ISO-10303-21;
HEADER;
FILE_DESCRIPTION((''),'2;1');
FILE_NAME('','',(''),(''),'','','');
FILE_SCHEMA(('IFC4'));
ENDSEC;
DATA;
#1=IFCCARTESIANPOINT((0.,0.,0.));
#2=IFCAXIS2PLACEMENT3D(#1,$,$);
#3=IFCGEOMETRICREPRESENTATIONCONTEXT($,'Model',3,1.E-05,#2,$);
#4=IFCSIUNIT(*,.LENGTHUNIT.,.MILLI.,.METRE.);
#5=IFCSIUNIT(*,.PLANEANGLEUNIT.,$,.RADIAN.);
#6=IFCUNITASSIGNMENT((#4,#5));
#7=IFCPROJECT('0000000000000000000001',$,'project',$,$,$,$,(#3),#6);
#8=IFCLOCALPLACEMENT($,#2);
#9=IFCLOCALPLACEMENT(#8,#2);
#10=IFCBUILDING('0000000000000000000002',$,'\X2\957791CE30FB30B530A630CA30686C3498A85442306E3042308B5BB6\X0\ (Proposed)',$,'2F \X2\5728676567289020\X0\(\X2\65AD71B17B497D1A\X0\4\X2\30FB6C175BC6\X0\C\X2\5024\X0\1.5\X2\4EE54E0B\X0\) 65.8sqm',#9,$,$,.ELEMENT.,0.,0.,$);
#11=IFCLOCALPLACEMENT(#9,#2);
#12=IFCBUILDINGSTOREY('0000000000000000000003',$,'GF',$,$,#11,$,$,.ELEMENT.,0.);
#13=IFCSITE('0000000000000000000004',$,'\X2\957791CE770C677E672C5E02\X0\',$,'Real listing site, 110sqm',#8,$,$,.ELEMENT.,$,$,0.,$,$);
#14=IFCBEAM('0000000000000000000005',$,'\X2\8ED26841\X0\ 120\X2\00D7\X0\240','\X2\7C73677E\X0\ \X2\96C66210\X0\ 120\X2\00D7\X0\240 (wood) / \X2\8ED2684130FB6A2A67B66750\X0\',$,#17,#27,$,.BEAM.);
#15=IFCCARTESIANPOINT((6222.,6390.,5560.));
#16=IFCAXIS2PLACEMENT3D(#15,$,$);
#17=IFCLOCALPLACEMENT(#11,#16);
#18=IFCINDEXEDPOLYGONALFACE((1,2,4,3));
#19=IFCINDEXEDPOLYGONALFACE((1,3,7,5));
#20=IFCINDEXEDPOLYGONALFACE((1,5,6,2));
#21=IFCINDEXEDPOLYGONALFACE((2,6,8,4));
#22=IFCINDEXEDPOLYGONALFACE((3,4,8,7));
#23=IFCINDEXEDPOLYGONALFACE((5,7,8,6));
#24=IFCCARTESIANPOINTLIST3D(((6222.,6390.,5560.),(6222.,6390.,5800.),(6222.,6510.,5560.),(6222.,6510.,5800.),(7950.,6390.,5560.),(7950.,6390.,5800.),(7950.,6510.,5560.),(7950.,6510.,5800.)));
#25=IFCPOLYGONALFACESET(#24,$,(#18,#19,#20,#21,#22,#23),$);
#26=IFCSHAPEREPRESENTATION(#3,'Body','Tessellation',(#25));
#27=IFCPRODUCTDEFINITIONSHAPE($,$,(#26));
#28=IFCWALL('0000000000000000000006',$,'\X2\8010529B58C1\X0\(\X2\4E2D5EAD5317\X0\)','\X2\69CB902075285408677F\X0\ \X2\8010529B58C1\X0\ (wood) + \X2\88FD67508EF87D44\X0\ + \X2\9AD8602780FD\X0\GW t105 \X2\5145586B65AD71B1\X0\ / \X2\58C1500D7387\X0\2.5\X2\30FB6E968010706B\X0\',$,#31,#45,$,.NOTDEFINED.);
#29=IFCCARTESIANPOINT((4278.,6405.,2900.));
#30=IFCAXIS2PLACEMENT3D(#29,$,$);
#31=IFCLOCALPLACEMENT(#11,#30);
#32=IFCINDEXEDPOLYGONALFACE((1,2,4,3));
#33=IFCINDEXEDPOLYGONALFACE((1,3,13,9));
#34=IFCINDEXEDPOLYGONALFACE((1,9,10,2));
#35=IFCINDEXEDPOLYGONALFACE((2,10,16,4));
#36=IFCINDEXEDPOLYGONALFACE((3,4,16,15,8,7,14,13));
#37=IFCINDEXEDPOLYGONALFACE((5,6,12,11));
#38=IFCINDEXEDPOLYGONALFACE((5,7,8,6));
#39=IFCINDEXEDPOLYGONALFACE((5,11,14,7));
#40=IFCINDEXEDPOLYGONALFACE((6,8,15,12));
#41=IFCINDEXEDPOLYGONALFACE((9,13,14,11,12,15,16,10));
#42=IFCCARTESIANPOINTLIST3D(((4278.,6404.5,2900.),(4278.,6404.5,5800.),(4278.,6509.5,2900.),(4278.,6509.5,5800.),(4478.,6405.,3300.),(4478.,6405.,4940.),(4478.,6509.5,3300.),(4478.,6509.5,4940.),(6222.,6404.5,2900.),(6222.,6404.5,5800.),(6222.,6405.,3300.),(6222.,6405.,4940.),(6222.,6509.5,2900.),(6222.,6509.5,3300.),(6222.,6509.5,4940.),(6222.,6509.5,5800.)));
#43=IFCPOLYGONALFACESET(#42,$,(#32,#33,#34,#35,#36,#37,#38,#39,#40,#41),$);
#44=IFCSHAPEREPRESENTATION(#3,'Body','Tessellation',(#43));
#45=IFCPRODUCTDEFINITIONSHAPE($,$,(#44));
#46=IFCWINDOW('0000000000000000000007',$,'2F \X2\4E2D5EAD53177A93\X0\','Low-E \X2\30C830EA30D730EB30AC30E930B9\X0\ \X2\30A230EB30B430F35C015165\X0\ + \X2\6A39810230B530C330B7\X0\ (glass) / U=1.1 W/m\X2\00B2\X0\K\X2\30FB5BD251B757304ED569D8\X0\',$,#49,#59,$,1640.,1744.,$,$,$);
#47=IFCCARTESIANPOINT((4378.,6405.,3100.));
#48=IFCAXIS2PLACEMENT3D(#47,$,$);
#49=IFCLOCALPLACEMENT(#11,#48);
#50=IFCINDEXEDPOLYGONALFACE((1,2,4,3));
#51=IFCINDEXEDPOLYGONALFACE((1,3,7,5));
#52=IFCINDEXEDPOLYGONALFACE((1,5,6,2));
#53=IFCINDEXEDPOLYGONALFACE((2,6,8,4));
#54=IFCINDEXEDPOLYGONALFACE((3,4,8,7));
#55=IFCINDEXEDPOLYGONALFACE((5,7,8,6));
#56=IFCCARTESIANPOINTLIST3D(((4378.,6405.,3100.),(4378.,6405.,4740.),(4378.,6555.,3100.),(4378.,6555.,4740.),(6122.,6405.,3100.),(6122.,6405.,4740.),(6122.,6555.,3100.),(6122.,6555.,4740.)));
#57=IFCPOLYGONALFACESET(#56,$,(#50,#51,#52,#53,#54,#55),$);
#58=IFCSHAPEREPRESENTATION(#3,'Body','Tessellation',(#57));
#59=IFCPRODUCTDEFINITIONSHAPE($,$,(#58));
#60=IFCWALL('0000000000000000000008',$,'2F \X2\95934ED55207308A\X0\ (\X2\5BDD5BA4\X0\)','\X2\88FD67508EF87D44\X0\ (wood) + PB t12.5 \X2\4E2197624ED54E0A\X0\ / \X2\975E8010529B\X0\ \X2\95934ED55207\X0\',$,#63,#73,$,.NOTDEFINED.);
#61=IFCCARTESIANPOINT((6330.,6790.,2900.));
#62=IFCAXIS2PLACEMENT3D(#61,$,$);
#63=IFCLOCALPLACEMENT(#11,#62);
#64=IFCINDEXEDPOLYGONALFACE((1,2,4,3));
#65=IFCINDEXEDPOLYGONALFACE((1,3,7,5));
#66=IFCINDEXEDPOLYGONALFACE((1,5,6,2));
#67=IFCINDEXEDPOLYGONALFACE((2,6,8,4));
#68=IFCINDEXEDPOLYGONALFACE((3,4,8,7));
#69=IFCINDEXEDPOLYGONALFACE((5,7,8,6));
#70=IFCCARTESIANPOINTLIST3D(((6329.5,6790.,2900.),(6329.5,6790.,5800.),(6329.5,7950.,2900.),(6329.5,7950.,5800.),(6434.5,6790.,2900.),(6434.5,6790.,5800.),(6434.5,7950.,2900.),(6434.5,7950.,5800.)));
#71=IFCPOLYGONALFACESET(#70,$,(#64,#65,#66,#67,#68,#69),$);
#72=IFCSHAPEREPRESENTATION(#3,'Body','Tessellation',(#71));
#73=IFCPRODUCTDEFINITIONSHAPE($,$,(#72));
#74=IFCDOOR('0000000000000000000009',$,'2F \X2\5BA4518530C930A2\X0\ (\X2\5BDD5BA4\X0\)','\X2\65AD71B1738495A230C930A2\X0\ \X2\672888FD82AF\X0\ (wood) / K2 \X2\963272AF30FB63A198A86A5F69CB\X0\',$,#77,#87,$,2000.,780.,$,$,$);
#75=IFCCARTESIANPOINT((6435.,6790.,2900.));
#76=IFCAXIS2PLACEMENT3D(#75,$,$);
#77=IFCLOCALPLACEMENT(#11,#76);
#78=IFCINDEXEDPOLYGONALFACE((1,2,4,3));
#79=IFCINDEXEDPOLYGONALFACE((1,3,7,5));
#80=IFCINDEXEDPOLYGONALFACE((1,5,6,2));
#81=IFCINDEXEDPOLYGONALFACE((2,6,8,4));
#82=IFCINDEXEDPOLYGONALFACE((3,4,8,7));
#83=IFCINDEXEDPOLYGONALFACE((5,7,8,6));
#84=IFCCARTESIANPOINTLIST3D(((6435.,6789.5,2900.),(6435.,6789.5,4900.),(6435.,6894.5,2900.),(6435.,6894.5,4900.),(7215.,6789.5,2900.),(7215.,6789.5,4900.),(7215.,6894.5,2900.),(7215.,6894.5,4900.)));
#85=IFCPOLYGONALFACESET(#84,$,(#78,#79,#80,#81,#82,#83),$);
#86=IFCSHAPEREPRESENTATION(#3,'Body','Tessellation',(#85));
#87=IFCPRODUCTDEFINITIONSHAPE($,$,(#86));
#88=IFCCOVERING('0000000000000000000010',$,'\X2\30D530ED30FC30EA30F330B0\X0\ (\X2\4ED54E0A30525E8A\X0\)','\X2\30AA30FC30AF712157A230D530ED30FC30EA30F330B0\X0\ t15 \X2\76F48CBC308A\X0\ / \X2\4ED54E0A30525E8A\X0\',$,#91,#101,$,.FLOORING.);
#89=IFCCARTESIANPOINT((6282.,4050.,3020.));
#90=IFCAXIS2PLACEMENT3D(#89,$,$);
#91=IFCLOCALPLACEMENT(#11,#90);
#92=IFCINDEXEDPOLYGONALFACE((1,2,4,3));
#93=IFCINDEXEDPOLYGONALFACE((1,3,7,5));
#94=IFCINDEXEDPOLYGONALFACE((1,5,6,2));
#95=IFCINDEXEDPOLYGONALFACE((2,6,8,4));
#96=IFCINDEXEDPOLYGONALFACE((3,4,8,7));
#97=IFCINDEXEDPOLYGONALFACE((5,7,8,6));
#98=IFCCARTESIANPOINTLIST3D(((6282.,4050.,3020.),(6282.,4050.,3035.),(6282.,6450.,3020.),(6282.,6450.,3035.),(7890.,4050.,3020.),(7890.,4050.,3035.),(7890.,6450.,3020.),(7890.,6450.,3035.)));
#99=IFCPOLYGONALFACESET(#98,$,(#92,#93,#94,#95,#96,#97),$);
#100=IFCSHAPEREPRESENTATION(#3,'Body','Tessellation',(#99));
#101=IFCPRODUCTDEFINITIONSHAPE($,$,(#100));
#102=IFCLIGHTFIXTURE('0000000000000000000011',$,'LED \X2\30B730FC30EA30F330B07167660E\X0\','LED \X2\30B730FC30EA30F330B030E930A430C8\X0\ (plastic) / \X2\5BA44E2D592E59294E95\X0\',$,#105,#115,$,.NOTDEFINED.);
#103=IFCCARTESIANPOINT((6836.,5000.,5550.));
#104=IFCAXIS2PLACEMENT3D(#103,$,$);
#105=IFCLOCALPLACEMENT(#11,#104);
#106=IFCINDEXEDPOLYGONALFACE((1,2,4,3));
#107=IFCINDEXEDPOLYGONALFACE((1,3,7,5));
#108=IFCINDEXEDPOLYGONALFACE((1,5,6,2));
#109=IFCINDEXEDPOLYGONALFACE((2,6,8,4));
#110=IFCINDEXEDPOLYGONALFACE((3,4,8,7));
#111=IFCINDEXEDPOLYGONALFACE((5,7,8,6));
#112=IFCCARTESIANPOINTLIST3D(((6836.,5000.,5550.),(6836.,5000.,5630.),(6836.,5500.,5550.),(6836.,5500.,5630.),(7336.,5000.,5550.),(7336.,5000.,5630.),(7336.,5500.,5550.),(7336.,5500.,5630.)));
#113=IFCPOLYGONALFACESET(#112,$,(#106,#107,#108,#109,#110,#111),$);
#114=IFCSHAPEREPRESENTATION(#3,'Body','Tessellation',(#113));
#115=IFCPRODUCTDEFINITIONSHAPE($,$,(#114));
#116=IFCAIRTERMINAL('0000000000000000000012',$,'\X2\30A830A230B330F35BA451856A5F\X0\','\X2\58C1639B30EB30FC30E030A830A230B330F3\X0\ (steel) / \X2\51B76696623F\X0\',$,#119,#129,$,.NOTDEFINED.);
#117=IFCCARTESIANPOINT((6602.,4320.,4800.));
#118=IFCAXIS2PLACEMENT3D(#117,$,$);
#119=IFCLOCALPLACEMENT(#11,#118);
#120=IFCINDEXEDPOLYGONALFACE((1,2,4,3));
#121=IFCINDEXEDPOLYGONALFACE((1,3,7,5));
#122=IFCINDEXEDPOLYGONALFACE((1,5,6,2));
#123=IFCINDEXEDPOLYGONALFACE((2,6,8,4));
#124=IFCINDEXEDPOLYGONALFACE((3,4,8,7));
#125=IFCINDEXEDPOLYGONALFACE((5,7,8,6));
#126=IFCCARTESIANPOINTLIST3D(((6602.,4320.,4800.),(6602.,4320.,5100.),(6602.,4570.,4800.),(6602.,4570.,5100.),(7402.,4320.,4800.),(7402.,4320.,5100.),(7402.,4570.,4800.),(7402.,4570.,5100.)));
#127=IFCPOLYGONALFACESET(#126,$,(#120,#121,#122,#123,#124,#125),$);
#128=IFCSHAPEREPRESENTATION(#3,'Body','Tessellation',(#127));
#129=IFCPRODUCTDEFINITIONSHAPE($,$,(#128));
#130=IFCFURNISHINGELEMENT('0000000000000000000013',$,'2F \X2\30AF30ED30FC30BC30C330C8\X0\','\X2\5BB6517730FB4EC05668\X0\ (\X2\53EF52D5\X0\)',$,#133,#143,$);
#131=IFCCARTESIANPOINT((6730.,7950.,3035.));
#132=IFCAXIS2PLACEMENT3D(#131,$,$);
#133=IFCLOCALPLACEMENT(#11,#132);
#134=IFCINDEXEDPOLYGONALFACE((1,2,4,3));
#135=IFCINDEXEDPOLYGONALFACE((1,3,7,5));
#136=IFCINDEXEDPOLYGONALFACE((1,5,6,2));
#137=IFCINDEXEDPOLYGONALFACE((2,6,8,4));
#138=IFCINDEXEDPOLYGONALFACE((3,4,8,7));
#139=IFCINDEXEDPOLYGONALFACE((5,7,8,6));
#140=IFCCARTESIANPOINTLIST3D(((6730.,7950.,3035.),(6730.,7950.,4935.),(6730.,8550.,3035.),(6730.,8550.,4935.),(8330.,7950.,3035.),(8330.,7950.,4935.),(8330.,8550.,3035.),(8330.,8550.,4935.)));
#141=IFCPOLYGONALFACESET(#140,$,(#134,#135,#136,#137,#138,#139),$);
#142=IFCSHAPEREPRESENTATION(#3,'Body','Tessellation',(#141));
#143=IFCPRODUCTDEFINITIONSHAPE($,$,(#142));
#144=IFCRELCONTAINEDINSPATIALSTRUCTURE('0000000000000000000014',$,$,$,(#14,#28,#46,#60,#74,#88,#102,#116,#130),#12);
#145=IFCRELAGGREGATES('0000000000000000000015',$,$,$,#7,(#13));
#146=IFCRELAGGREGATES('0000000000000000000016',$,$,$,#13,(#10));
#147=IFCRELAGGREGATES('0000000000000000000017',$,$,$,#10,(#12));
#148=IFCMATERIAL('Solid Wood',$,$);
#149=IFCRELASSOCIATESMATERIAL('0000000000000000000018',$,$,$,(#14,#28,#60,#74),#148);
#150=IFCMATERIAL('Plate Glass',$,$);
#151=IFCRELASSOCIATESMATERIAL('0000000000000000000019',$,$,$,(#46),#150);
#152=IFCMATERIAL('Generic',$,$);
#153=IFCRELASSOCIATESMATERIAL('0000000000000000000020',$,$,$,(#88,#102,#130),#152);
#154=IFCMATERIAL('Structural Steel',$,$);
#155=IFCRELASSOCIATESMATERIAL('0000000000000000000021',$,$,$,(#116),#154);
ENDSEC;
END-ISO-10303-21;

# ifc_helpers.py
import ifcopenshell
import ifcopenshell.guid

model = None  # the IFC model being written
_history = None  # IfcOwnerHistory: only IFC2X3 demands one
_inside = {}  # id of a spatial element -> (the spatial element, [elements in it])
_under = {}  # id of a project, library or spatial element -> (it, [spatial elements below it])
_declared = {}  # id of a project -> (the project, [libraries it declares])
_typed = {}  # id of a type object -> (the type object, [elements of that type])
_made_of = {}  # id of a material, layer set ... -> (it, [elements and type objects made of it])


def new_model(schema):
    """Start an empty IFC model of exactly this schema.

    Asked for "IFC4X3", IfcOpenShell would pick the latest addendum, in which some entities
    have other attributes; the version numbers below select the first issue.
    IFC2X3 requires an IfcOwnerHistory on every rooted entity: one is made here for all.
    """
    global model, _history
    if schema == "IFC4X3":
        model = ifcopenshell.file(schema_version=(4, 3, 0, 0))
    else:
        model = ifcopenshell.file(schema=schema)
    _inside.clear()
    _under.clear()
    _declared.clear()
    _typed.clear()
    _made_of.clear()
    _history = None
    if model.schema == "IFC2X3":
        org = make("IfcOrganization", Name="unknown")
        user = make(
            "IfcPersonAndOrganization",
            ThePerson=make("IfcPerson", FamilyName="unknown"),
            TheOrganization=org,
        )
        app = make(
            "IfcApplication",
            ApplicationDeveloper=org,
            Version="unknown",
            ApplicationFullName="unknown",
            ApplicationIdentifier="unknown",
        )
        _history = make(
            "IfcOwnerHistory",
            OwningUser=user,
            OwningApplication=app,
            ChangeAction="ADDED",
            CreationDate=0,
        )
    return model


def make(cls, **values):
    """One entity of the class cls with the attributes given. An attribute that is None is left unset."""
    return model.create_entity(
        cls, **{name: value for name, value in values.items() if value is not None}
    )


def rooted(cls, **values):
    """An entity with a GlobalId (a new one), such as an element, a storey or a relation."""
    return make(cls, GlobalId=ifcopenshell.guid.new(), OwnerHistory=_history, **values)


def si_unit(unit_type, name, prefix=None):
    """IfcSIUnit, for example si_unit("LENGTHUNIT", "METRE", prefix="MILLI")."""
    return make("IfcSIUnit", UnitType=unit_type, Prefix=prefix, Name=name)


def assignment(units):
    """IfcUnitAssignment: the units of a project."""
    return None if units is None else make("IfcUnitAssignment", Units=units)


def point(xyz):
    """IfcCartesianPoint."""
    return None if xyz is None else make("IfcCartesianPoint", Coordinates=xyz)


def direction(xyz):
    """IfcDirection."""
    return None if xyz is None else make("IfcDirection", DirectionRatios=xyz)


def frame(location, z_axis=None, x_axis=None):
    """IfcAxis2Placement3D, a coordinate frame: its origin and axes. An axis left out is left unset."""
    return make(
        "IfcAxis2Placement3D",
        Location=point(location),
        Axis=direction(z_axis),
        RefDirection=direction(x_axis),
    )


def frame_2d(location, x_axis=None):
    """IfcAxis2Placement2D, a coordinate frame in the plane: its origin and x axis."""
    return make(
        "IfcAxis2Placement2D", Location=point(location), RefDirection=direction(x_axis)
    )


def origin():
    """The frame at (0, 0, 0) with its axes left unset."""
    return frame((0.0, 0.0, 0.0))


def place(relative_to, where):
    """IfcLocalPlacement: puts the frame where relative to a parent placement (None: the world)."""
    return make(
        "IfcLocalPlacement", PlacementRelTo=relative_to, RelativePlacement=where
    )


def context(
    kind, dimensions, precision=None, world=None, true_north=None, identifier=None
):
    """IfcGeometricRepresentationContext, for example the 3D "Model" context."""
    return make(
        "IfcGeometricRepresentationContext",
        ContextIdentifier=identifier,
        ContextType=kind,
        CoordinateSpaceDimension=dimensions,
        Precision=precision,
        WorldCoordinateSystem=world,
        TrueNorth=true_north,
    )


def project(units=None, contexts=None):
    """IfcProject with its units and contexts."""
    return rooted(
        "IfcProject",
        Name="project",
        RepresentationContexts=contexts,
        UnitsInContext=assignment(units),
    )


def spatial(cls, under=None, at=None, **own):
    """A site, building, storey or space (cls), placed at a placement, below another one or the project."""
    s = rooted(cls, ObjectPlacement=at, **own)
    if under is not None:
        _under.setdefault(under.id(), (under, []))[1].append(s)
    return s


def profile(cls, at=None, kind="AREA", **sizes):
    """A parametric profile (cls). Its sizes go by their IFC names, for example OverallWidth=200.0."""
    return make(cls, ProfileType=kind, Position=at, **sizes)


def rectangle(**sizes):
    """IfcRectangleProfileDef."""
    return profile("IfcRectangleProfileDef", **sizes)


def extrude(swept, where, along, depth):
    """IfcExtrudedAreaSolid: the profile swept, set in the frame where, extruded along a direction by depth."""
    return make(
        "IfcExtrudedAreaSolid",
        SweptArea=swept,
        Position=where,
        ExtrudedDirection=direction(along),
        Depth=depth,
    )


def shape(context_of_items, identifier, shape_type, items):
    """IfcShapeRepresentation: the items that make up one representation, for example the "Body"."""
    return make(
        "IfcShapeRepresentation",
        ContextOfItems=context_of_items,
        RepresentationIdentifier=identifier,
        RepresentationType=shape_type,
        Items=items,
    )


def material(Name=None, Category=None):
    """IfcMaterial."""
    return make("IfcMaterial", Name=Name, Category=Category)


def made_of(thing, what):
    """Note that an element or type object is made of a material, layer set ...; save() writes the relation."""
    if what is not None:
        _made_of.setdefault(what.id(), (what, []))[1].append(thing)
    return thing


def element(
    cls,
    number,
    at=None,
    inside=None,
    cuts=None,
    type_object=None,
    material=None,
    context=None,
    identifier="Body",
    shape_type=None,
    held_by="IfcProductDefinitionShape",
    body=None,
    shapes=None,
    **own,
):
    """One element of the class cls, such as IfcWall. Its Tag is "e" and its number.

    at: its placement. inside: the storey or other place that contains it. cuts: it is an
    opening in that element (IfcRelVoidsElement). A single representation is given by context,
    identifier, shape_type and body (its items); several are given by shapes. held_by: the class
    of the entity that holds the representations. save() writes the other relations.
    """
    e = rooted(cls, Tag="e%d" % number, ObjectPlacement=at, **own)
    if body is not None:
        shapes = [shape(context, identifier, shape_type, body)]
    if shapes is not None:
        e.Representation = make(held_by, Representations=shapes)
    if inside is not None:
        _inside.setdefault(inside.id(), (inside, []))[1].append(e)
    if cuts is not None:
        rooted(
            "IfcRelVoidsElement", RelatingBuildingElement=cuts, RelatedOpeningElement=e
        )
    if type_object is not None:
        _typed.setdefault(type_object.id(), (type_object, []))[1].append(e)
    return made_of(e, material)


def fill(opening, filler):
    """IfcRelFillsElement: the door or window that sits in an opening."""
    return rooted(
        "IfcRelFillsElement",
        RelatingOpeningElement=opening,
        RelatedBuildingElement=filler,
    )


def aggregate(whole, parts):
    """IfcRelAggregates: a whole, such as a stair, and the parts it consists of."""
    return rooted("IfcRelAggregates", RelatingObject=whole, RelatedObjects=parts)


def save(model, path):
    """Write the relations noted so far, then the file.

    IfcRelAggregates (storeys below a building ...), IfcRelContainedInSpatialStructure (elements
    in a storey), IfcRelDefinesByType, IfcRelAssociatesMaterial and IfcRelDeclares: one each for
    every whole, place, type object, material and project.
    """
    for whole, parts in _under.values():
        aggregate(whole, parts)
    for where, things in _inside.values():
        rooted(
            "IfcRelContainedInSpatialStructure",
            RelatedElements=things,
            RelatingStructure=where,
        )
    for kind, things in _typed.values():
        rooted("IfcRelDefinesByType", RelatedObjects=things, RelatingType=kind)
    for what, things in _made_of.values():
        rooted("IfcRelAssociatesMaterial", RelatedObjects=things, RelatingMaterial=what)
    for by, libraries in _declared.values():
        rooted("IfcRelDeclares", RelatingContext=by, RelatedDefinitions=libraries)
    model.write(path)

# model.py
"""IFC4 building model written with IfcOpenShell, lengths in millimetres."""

from ifc_helpers import new_model, si_unit, frame, frame_2d, origin, place, context, project, spatial, rectangle, extrude, material, element, fill, save


model = new_model("IFC4")

# Units and contexts
model_context = context("Model", 3, precision=1e-05, world=origin())
ifc_project = project(units=[si_unit("LENGTHUNIT", "METRE", prefix="MILLI"), si_unit("PLANEANGLEUNIT", "RADIAN")], contexts=[model_context])

# Site, building, storey
site_placement = place(None, origin())
site = spatial("IfcSite", under=ifc_project, at=site_placement, Name="長野県松本市", ObjectType="Real listing site, 110sqm", CompositionType="ELEMENT", RefElevation=0.0)
building_placement = place(site_placement, origin())
building = spatial("IfcBuilding", under=site, at=building_placement, Name="長野・サウナと水風呂のある家 (Proposed)", ObjectType="2F 在来木造(断熱等級4・気密C値1.5以下) 65.8sqm", CompositionType="ELEMENT", ElevationOfRefHeight=0.0, ElevationOfTerrain=0.0)
storey_placement = place(building_placement, origin())
storey = spatial("IfcBuildingStorey", under=building, at=storey_placement, Name="GF", CompositionType="ELEMENT", Elevation=0.0)

# Shared definitions
ifc_material_1 = material(Name="Solid Wood")

# Beam
beam_1_placement = place(storey_placement, frame((6222.0, 6390.0, 5560.0)))
element("IfcBeam", 1, at=beam_1_placement, inside=storey, material=ifc_material_1, Name="軒桁 120×240", Description="米松 集成 120×240 (wood) / 軒桁・横架材", PredefinedType="BEAM", context=model_context, shape_type="SweptSolid", body=[
    extrude(rectangle(XDim=1728.0, YDim=120.0, at=frame_2d((864.0, 60.0))), frame((6222.0, 6390.0, 5560.0)), (0.0, 0.0, 1.0), 240.0),
])

# Wall, opening, window
wall_1_placement = place(storey_placement, frame((4278.0, 6405.0, 2900.0)))
wall_1 = element("IfcWall", 2, at=wall_1_placement, inside=storey, material=ifc_material_1, Name="耐力壁(中庭北)", Description="構造用合板 耐力壁 (wood) + 製材軸組 + 高性能GW t105 充填断熱 / 壁倍率2.5・準耐火", PredefinedType="NOTDEFINED", context=model_context, shape_type="SweptSolid", body=[
    extrude(rectangle(XDim=1944.0, YDim=105.0, at=frame_2d((972.0, 52.0))), frame((4278.0, 6405.0, 2900.0)), (0.0, 0.0, 1.0), 2900.0),
])
opening_placement = place(storey_placement, frame((4378.0, 6405.0, 3100.0)))
opening = element("IfcOpeningElement", 3, at=opening_placement, cuts=wall_1, PredefinedType="NOTDEFINED", context=model_context, shape_type="SweptSolid", body=[
    extrude(rectangle(XDim=1744.0, YDim=150.0, at=frame_2d((872.0, 75.0))), frame((4378.0, 6405.0, 3100.0)), (0.0, 0.0, 1.0), 1640.0),
])
ifc_material_2 = material(Name="Plate Glass")
window_placement = place(storey_placement, frame((4378.0, 6405.0, 3100.0)))
window = element("IfcWindow", 4, at=window_placement, inside=storey, material=ifc_material_2, Name="2F 中庭北窓", Description="Low-E トリプルガラス アルゴン封入 + 樹脂サッシ (glass) / U=1.1 W/m²K・寒冷地仕様", OverallHeight=1640.0, OverallWidth=1744.0, context=model_context, shape_type="SweptSolid", body=[
    extrude(rectangle(XDim=1744.0, YDim=150.0, at=frame_2d((872.0, 75.0))), frame((4378.0, 6405.0, 3100.0)), (0.0, 0.0, 1.0), 1640.0),
])
fill(opening, window)

# Wall
wall_2_placement = place(storey_placement, frame((6330.0, 6790.0, 2900.0)))
element("IfcWall", 5, at=wall_2_placement, inside=storey, material=ifc_material_1, Name="2F 間仕切り (寝室)", Description="製材軸組 (wood) + PB t12.5 両面仕上 / 非耐力 間仕切", PredefinedType="NOTDEFINED", context=model_context, shape_type="SweptSolid", body=[
    extrude(rectangle(XDim=105.0, YDim=1160.0, at=frame_2d((52.0, 580.0))), frame((6330.0, 6790.0, 2900.0)), (0.0, 0.0, 1.0), 2900.0),
])

# Door
door_placement = place(storey_placement, frame((6435.0, 6790.0, 2900.0)))
element("IfcDoor", 6, at=door_placement, inside=storey, material=ifc_material_1, Name="2F 室内ドア (寝室)", Description="断熱玄関ドア 木製芯 (wood) / K2 防犯・採風機構", OverallHeight=2000.0, OverallWidth=780.0, context=model_context, shape_type="SweptSolid", body=[
    extrude(rectangle(XDim=780.0, YDim=105.0, at=frame_2d((390.0, 52.0))), frame((6435.0, 6790.0, 2900.0)), (0.0, 0.0, 1.0), 2000.0),
])

# Covering
ifc_material_3 = material(Name="Generic")
covering_placement = place(storey_placement, frame((6282.0, 4050.0, 3020.0)))
element("IfcCovering", 7, at=covering_placement, inside=storey, material=ifc_material_3, Name="フローリング (仕上げ床)", Description="オーク無垢フローリング t15 直貼り / 仕上げ床", PredefinedType="FLOORING", context=model_context, shape_type="SweptSolid", body=[
    extrude(rectangle(XDim=1608.0, YDim=2400.0, at=frame_2d((804.0, 1200.0))), frame((6282.0, 4050.0, 3020.0)), (0.0, 0.0, 1.0), 15.0),
])

# Light fixture
light_fixture_placement = place(storey_placement, frame((6836.0, 5000.0, 5550.0)))
element("IfcLightFixture", 8, at=light_fixture_placement, inside=storey, material=ifc_material_3, Name="LED シーリング照明", Description="LED シーリングライト (plastic) / 室中央天井", PredefinedType="NOTDEFINED", context=model_context, shape_type="SweptSolid", body=[
    extrude(rectangle(XDim=500.0, YDim=500.0, at=frame_2d((250.0, 250.0))), frame((6836.0, 5000.0, 5550.0)), (0.0, 0.0, 1.0), 80.0),
])

# Air terminal
ifc_material_4 = material(Name="Structural Steel")
air_terminal_placement = place(storey_placement, frame((6602.0, 4320.0, 4800.0)))
element("IfcAirTerminal", 9, at=air_terminal_placement, inside=storey, material=ifc_material_4, Name="エアコン室内機", Description="壁掛ルームエアコン (steel) / 冷暖房", PredefinedType="NOTDEFINED", context=model_context, shape_type="SweptSolid", body=[
    extrude(rectangle(XDim=800.0, YDim=250.0, at=frame_2d((400.0, 125.0))), frame((6602.0, 4320.0, 4800.0)), (0.0, 0.0, 1.0), 300.0),
])

# Furnishing element
furnishing_placement = place(storey_placement, frame((6730.0, 7950.0, 3035.0)))
element("IfcFurnishingElement", 10, at=furnishing_placement, inside=storey, material=ifc_material_3, Name="2F クローゼット", Description="家具・什器 (可動)", context=model_context, shape_type="SweptSolid", body=[
    extrude(rectangle(XDim=1600.0, YDim=600.0, at=frame_2d((800.0, 300.0))), frame((6730.0, 7950.0, 3035.0)), (0.0, 0.0, 1.0), 1900.0),
])

save(model, "model.ifc")
